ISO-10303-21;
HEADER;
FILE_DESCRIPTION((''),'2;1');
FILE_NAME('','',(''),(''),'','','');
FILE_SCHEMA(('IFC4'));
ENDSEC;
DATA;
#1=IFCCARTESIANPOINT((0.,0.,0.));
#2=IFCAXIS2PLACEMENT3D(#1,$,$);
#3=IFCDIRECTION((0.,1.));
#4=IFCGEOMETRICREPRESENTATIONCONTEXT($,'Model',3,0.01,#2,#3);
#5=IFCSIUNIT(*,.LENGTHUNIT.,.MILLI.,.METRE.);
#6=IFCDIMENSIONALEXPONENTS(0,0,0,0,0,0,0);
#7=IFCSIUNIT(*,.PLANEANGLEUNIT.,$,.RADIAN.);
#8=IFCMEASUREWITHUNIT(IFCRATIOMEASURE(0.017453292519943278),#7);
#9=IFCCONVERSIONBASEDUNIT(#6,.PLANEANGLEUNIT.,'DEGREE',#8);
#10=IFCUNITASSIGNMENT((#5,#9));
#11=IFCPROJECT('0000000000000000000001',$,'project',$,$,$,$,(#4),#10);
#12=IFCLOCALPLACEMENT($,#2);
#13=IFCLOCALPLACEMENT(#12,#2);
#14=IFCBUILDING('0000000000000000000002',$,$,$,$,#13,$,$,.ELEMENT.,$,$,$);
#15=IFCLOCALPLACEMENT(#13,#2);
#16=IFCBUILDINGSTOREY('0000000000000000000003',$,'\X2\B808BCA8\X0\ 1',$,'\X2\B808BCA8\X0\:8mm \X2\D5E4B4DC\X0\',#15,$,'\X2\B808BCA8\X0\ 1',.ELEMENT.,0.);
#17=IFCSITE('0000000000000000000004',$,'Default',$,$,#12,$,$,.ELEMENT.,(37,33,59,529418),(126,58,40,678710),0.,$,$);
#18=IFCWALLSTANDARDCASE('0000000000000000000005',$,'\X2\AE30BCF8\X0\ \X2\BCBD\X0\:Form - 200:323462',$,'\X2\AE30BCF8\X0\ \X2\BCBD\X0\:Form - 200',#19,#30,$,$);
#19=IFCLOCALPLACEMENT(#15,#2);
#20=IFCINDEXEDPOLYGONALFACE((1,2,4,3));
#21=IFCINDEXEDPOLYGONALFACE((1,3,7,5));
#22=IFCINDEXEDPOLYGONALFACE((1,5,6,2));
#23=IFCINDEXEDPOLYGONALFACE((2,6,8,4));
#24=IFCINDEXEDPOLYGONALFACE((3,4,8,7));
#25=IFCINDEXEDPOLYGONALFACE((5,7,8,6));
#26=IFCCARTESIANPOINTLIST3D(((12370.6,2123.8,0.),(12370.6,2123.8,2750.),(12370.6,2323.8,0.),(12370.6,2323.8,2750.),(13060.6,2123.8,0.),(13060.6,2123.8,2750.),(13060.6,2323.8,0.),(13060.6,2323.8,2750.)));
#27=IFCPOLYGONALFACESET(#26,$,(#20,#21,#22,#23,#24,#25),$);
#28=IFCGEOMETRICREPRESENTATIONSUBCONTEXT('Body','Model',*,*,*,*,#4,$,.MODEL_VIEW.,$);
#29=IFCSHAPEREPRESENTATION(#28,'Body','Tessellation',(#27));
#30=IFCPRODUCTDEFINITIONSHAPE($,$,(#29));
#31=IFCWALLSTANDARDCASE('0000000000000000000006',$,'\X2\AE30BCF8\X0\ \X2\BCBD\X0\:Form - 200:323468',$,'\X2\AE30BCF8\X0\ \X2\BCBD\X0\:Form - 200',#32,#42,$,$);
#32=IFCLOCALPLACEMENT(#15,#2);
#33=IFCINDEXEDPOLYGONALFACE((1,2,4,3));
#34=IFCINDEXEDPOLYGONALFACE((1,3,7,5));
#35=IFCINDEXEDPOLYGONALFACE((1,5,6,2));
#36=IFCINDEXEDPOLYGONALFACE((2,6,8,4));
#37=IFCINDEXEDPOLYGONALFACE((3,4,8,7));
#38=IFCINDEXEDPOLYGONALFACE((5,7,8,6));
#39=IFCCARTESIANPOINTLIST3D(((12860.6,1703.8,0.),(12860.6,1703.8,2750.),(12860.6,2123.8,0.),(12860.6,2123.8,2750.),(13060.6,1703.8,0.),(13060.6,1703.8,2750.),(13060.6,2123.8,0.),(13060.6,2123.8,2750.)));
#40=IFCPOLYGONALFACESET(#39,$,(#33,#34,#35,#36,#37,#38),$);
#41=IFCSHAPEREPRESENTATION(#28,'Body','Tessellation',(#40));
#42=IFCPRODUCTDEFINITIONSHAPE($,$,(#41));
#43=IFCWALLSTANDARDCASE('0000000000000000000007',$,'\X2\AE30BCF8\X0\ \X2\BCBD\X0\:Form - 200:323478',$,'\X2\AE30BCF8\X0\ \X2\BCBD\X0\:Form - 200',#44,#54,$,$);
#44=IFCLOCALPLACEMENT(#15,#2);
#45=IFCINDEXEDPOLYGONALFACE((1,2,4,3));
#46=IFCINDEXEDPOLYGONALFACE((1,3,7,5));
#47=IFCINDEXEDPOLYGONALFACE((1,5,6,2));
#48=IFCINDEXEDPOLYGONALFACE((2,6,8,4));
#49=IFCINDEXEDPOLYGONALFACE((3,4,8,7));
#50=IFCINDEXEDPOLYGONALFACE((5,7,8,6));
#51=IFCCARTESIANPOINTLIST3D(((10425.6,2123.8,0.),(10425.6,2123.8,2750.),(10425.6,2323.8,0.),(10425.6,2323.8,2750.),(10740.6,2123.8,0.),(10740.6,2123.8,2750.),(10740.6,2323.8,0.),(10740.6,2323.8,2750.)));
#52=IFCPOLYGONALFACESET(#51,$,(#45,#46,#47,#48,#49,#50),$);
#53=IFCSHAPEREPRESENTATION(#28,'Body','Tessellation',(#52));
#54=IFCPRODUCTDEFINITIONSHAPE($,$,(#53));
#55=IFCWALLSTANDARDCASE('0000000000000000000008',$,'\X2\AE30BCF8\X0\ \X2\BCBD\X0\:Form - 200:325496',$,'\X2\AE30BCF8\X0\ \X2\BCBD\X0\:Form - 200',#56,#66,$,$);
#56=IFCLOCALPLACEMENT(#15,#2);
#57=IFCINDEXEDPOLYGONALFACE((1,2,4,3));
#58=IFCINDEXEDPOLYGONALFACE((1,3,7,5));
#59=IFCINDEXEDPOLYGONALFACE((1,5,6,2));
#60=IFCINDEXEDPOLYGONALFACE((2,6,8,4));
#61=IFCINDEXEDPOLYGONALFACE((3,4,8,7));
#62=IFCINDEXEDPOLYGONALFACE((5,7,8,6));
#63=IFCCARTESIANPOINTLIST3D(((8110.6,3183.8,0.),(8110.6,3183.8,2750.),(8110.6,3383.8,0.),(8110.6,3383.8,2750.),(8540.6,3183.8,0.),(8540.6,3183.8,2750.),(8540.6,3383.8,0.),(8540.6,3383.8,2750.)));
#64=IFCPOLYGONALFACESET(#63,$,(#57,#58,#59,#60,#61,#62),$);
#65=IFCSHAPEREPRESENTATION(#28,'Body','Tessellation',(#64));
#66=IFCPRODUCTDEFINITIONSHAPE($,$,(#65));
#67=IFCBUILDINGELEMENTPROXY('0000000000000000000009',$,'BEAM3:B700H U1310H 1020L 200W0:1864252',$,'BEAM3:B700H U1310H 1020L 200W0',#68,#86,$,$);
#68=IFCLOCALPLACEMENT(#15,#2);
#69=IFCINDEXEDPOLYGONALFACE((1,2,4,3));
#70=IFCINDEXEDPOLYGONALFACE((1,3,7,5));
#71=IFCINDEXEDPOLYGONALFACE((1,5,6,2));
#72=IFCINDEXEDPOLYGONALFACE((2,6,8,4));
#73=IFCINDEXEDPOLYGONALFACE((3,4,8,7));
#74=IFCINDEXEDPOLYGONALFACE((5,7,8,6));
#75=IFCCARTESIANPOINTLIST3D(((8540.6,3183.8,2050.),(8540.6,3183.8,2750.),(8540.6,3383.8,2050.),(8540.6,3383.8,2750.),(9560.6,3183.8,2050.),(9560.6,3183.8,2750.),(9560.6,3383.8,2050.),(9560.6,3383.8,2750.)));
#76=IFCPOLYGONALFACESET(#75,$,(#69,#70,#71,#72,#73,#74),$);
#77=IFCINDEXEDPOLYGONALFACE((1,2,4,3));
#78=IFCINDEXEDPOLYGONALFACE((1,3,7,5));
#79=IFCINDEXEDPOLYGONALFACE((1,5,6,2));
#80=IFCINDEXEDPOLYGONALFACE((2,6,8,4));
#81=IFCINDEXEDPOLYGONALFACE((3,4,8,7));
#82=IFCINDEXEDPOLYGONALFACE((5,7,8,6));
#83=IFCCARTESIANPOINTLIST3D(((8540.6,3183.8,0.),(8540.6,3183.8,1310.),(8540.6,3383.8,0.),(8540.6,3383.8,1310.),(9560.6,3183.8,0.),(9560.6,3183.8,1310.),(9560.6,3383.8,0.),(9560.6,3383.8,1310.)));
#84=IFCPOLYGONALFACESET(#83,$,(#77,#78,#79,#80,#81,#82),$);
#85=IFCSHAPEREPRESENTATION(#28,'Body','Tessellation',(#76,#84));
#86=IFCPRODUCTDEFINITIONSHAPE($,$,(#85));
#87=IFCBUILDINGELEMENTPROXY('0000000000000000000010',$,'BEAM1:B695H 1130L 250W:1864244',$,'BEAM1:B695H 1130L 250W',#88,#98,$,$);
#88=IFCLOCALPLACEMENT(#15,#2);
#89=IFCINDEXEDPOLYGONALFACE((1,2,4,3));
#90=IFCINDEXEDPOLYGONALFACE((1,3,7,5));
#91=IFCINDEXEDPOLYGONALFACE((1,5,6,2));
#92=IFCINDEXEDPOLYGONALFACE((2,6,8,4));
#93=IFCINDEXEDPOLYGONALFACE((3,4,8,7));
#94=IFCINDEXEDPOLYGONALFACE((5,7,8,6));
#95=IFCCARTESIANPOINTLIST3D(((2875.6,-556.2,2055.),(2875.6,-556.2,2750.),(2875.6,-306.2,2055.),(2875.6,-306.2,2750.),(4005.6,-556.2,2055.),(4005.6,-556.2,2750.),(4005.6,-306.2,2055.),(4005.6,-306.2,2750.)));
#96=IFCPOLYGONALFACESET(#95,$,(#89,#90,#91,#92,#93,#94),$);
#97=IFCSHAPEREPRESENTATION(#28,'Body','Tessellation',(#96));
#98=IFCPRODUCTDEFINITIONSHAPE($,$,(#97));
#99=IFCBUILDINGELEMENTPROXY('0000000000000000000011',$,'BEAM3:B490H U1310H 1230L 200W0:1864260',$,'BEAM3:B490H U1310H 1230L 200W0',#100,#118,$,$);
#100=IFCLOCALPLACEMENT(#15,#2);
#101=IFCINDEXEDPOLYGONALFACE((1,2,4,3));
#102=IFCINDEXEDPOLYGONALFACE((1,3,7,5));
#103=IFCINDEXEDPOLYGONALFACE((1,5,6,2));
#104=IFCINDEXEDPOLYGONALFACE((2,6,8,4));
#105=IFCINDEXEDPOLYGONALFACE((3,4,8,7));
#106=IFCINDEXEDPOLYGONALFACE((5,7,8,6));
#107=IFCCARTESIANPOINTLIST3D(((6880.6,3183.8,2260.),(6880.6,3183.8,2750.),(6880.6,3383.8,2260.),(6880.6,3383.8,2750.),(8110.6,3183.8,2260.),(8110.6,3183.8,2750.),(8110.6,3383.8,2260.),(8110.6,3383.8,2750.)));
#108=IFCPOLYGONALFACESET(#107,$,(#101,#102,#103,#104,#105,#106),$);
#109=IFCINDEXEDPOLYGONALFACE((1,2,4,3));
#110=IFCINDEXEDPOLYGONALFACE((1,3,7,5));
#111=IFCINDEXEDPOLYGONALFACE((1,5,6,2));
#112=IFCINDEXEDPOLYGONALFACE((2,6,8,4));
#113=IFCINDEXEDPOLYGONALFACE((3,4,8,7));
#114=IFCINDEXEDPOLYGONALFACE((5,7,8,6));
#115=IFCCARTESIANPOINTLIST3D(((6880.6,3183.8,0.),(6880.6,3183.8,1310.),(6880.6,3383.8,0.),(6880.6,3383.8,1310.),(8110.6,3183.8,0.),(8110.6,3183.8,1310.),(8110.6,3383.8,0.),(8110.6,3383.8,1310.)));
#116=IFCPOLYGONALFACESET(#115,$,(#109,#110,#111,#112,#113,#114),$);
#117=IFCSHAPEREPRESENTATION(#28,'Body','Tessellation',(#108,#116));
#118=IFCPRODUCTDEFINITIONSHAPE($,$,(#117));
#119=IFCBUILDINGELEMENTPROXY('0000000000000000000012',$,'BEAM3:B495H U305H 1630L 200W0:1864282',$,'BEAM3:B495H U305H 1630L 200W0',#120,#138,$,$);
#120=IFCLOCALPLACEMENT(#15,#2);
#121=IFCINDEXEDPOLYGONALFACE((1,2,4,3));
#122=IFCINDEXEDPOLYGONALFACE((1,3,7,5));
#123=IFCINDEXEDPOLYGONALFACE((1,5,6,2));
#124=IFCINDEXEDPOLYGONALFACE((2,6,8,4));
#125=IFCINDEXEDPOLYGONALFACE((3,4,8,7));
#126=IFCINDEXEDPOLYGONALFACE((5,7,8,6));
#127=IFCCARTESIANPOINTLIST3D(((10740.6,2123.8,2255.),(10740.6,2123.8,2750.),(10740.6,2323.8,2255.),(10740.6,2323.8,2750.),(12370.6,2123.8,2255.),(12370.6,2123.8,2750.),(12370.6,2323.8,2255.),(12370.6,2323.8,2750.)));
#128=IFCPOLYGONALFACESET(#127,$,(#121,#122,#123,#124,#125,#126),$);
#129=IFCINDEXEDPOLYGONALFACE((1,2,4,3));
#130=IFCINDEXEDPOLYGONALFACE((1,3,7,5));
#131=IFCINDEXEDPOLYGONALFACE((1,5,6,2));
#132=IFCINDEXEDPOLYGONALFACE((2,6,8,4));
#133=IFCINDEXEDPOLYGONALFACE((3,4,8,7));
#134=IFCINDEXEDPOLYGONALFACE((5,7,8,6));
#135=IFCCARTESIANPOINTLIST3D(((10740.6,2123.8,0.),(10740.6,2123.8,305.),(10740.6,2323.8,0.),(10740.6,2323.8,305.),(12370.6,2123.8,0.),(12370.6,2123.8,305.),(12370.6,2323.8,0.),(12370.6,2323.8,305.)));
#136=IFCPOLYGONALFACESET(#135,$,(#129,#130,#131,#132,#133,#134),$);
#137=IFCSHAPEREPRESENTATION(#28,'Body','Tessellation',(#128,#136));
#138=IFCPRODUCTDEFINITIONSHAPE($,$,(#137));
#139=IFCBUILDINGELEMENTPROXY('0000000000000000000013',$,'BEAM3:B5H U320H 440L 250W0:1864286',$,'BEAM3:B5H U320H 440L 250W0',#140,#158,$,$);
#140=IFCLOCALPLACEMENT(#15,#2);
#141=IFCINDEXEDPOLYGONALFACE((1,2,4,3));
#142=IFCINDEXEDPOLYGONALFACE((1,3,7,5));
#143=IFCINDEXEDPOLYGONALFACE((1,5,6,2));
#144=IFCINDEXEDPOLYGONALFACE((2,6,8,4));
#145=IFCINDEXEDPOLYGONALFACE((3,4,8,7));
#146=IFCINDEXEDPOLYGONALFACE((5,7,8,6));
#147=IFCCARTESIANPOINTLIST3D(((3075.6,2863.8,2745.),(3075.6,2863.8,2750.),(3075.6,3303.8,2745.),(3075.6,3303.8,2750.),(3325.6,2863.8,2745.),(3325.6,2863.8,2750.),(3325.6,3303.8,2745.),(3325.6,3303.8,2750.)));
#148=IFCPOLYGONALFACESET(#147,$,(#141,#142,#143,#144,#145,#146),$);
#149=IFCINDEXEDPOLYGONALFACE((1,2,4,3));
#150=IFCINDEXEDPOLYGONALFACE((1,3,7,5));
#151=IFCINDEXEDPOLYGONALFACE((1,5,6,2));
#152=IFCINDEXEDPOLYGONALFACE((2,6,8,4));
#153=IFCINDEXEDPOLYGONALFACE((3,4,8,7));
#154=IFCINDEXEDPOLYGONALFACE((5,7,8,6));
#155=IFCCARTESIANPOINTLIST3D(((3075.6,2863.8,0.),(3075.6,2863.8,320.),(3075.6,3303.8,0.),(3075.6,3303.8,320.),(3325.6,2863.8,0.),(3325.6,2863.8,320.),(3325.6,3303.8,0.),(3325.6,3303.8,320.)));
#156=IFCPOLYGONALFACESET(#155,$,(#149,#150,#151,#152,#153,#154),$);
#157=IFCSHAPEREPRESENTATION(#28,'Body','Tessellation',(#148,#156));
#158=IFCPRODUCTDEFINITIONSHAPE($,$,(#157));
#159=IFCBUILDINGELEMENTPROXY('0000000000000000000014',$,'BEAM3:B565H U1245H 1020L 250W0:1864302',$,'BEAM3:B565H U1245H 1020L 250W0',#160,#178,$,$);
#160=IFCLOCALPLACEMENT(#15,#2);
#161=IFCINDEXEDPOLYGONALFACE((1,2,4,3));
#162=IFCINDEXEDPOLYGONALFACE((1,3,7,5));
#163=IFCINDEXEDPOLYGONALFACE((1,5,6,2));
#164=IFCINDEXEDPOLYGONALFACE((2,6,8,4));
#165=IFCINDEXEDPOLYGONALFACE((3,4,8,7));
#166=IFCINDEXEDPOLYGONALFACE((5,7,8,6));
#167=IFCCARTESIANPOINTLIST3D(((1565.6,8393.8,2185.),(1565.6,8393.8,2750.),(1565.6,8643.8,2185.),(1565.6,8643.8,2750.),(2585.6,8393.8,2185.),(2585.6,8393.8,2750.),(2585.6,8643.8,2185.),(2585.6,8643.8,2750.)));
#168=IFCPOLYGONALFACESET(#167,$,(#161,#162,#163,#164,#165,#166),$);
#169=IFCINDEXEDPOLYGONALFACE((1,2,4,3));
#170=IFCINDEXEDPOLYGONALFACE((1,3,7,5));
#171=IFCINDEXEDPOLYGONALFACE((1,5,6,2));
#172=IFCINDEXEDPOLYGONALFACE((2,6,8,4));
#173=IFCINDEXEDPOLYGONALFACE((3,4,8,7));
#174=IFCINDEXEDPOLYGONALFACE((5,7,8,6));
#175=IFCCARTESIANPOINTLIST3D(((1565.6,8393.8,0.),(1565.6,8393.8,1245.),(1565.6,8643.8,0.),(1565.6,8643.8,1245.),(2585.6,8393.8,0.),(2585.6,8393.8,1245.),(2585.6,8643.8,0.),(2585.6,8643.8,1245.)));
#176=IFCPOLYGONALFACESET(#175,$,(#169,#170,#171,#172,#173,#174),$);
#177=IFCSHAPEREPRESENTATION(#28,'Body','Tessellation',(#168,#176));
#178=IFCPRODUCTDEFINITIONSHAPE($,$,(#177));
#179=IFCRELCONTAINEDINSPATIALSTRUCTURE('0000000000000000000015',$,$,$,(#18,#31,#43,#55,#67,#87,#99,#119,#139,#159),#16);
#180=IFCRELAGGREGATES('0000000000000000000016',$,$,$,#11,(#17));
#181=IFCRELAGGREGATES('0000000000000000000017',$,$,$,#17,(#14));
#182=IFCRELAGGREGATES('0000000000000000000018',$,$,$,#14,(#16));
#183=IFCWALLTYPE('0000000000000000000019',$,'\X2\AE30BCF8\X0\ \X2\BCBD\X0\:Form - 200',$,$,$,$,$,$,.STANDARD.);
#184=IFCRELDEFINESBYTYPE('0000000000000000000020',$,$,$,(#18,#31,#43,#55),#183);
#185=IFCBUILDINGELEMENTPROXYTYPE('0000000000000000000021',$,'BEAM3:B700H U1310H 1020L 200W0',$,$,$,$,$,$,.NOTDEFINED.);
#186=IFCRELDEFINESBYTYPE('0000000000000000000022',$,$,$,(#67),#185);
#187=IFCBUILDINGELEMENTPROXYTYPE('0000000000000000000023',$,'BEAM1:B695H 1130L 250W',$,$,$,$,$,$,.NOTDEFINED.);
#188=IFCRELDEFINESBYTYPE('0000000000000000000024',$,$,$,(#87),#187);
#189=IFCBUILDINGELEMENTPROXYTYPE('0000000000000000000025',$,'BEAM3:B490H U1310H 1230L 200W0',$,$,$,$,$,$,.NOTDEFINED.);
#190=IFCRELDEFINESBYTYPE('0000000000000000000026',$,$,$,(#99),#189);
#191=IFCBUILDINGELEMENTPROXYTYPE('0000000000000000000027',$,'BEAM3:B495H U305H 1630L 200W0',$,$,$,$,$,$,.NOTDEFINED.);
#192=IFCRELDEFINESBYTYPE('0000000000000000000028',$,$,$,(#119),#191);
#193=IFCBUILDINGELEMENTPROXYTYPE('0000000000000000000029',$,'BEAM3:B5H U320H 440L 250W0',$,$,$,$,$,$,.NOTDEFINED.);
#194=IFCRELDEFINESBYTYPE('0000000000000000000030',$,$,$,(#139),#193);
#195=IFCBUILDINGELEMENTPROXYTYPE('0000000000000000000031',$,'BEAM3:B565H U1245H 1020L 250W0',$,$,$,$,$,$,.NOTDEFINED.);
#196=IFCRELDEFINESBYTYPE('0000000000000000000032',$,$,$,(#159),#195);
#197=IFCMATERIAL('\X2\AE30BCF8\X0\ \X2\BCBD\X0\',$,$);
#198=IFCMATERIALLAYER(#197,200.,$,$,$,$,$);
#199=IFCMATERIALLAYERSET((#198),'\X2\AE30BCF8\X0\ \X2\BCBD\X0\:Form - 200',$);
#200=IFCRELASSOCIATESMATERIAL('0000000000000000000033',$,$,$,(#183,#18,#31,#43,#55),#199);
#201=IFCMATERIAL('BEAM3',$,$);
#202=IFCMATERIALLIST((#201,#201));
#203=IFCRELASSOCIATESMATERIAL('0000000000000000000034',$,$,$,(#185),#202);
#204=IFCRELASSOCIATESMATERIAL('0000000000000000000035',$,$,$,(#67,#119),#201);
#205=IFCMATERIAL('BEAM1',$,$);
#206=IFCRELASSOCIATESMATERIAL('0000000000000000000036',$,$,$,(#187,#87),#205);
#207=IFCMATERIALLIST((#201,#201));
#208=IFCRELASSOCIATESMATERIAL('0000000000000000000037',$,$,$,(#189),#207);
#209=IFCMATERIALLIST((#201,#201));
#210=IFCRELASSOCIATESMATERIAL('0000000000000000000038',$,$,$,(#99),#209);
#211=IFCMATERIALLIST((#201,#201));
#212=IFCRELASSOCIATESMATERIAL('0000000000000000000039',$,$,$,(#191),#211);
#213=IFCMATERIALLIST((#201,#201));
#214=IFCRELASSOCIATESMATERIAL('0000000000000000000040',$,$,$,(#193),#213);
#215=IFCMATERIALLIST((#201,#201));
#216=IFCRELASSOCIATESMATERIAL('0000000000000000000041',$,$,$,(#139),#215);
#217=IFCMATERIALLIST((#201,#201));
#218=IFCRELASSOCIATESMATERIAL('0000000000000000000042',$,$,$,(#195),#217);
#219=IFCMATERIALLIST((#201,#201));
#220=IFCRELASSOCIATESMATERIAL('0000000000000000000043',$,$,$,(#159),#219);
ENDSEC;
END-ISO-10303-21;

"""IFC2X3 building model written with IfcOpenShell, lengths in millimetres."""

from ifc_helpers import new_model, entity, si_unit, converted_unit, direction, frame, frame_2d, origin, origin_2d_with_axis, place, context, subcontext, project, spatial, rectangle, extrude, source, transform, mapped, material, material_list, layer, layer_set, layer_usage, type_object, type_shapes, element, save


model = new_model("IFC2X3")

# Units and contexts
model_context = context("Model", 3, precision=0.01, world=origin(), true_north=direction((0.0, 1.0)))
body_context = subcontext(model_context, "Body", "Model", "MODEL_VIEW")
ifc_project = project(units=[si_unit("LENGTHUNIT", "METRE", prefix="MILLI"), converted_unit("PLANEANGLEUNIT", "DEGREE", entity("IfcRatioMeasure", 0.017453292519943278), si_unit("PLANEANGLEUNIT", "RADIAN"), dimensions=[0, 0, 0, 0, 0, 0, 0])], contexts=[model_context])

# Site, building, storey
site_placement = place(None, origin())
site = spatial("IfcSite", under=ifc_project, at=site_placement, Name="Default", CompositionType="ELEMENT", RefLatitude=(37, 33, 59, 529418), RefLongitude=(126, 58, 40, 678710), RefElevation=0.0)
building_placement = place(site_placement, origin())
building = spatial("IfcBuilding", under=site, at=building_placement, CompositionType="ELEMENT")
storey_placement = place(building_placement, origin())
storey = spatial("IfcBuildingStorey", under=building, at=storey_placement, Name="레벨 1", ObjectType="레벨:8mm 헤드", LongName="레벨 1", CompositionType="ELEMENT", Elevation=0.0)

# Walls
ifc_material_1 = material(Name="기본 벽")
ifc_layer_1 = layer(ifc_material_1, 200.0)
ifc_layer_set_1 = layer_set([ifc_layer_1], Name="기본 벽:Form - 200")
wall_type_1 = type_object("IfcWallType", Name="기본 벽:Form - 200", PredefinedType="STANDARD", material=ifc_layer_set_1)
ifc_layer_usage_1 = layer_usage(ifc_layer_set_1, "AXIS2", "POSITIVE", -100.0)
wall_1_placement = place(storey_placement, frame((13060.6, 2223.8, 0.0), z_axis=(0.0, 0.0, 1.0), x_axis=(-1.0, 0.0, 0.0)))
element("IfcWallStandardCase", 1, at=wall_1_placement, inside=storey, type_object=wall_type_1, material=ifc_layer_usage_1, Name="기본 벽:Form - 200:323462", ObjectType="기본 벽:Form - 200", context=body_context, shape_type="SweptSolid", body=[
    extrude(rectangle(XDim=690.0, YDim=200.0, at=frame_2d((345.0, 0.0), x_axis=(-1.0, 0.0))), origin(), (0.0, 0.0, 1.0), 2750.0),
])
ifc_layer_usage_2 = layer_usage(ifc_layer_set_1, "AXIS2", "POSITIVE", -100.0)
wall_2_placement = place(storey_placement, frame((12960.6, 1703.8, 0.0), z_axis=(0.0, 0.0, 1.0), x_axis=(0.0, 1.0, 0.0)))
element("IfcWallStandardCase", 2, at=wall_2_placement, inside=storey, type_object=wall_type_1, material=ifc_layer_usage_2, Name="기본 벽:Form - 200:323468", ObjectType="기본 벽:Form - 200", context=body_context, shape_type="SweptSolid", body=[
    extrude(rectangle(XDim=420.0, YDim=200.0, at=frame_2d((210.0, 0.0), x_axis=(-1.0, 0.0))), origin(), (0.0, 0.0, 1.0), 2750.0),
])
ifc_layer_usage_3 = layer_usage(ifc_layer_set_1, "AXIS2", "POSITIVE", -100.0)
wall_3_placement = place(storey_placement, frame((10740.6, 2223.8, 0.0), z_axis=(0.0, 0.0, 1.0), x_axis=(-1.0, 0.0, 0.0)))
element("IfcWallStandardCase", 3, at=wall_3_placement, inside=storey, type_object=wall_type_1, material=ifc_layer_usage_3, Name="기본 벽:Form - 200:323478", ObjectType="기본 벽:Form - 200", context=body_context, shape_type="SweptSolid", body=[
    extrude(rectangle(XDim=315.0, YDim=200.0, at=frame_2d((157.5, 0.0), x_axis=(-1.0, 0.0))), origin(), (0.0, 0.0, 1.0), 2750.0),
])
ifc_layer_usage_4 = layer_usage(ifc_layer_set_1, "AXIS2", "POSITIVE", -100.0)
wall_4_placement = place(storey_placement, frame((8110.6, 3283.8, 0.0)))
element("IfcWallStandardCase", 4, at=wall_4_placement, inside=storey, type_object=wall_type_1, material=ifc_layer_usage_4, Name="기본 벽:Form - 200:325496", ObjectType="기본 벽:Form - 200", context=body_context, shape_type="SweptSolid", body=[
    extrude(rectangle(XDim=430.0, YDim=200.0, at=frame_2d((215.0, 0.0), x_axis=(-1.0, 0.0))), origin(), (0.0, 0.0, 1.0), 2750.0),
])

# Building element proxies
ifc_material_2 = material(Name="BEAM3")
ifc_material_list_1 = material_list([ifc_material_2, ifc_material_2])
building_element_proxy_type_1 = type_object("IfcBuildingElementProxyType", Name="BEAM3:B700H U1310H 1020L 200W0", PredefinedType="NOTDEFINED", material=ifc_material_list_1)
shared_shape_1 = source(origin(), body_context, "Body", "SweptSolid", [
    extrude(rectangle(XDim=1020.0, YDim=200.0, at=origin_2d_with_axis()), frame((510.0, -100.0, 2050.0)), (0.0, 0.0, 1.0), 700.0),
    extrude(rectangle(XDim=1020.0, YDim=200.0, at=origin_2d_with_axis()), frame((510.0, -100.0, 0.0)), (0.0, 0.0, 1.0), 1310.0),
])
type_shapes(building_element_proxy_type_1, [shared_shape_1])
proxy_1_placement = place(storey_placement, frame((9560.6, 3183.8, 0.0), z_axis=(0.0, 0.0, 1.0), x_axis=(-1.0, 0.0, 0.0)))
element("IfcBuildingElementProxy", 5, at=proxy_1_placement, inside=storey, type_object=building_element_proxy_type_1, material=ifc_material_2, Name="BEAM3:B700H U1310H 1020L 200W0:1864252", ObjectType="BEAM3:B700H U1310H 1020L 200W0", context=body_context, shape_type="MappedRepresentation", body=[
    mapped(shared_shape_1, transform((0.0, 0.0, 0.0), scale=1.0)),
])
ifc_material_3 = material(Name="BEAM1")
building_element_proxy_type_2 = type_object("IfcBuildingElementProxyType", Name="BEAM1:B695H 1130L 250W", PredefinedType="NOTDEFINED", material=ifc_material_3)
shared_shape_2 = source(origin(), body_context, "Body", "SweptSolid", [
    extrude(rectangle(XDim=1130.0, YDim=250.0, at=origin_2d_with_axis()), frame((565.0, -125.0, -695.0)), (0.0, 0.0, 1.0), 695.0),
])
type_shapes(building_element_proxy_type_2, [shared_shape_2])
proxy_2_placement = place(storey_placement, frame((2875.6, -306.2, 2750.0)))
element("IfcBuildingElementProxy", 6, at=proxy_2_placement, inside=storey, type_object=building_element_proxy_type_2, material=ifc_material_3, Name="BEAM1:B695H 1130L 250W:1864244", ObjectType="BEAM1:B695H 1130L 250W", context=body_context, shape_type="MappedRepresentation", body=[
    mapped(shared_shape_2, transform((0.0, 0.0, 0.0), scale=1.0)),
])
ifc_material_list_2 = material_list([ifc_material_2, ifc_material_2])
ifc_material_list_3 = material_list([ifc_material_2, ifc_material_2])
building_element_proxy_type_3 = type_object("IfcBuildingElementProxyType", Name="BEAM3:B490H U1310H 1230L 200W0", PredefinedType="NOTDEFINED", material=ifc_material_list_3)
shared_shape_3 = source(origin(), body_context, "Body", "SweptSolid", [
    extrude(rectangle(XDim=1230.0, YDim=200.0, at=origin_2d_with_axis()), frame((615.0, -100.0, 2260.0)), (0.0, 0.0, 1.0), 490.0),
    extrude(rectangle(XDim=1230.0, YDim=200.0, at=origin_2d_with_axis()), frame((615.0, -100.0, 0.0)), (0.0, 0.0, 1.0), 1310.0),
])
type_shapes(building_element_proxy_type_3, [shared_shape_3])
proxy_3_placement = place(storey_placement, frame((8110.6, 3183.8, 0.0), z_axis=(0.0, 0.0, 1.0), x_axis=(-1.0, 0.0, 0.0)))
element("IfcBuildingElementProxy", 7, at=proxy_3_placement, inside=storey, type_object=building_element_proxy_type_3, material=ifc_material_list_2, Name="BEAM3:B490H U1310H 1230L 200W0:1864260", ObjectType="BEAM3:B490H U1310H 1230L 200W0", context=body_context, shape_type="MappedRepresentation", body=[
    mapped(shared_shape_3, transform((0.0, 0.0, 0.0), scale=1.0)),
])
ifc_material_list_4 = material_list([ifc_material_2, ifc_material_2])
building_element_proxy_type_4 = type_object("IfcBuildingElementProxyType", Name="BEAM3:B495H U305H 1630L 200W0", PredefinedType="NOTDEFINED", material=ifc_material_list_4)
shared_shape_4 = source(origin(), body_context, "Body", "SweptSolid", [
    extrude(rectangle(XDim=1630.0, YDim=200.0, at=origin_2d_with_axis()), frame((815.0, -100.0, 2255.0)), (0.0, 0.0, 1.0), 495.0),
    extrude(rectangle(XDim=1630.0, YDim=200.0, at=origin_2d_with_axis()), frame((815.0, -100.0, 0.0)), (0.0, 0.0, 1.0), 305.0),
])
type_shapes(building_element_proxy_type_4, [shared_shape_4])
proxy_4_placement = place(storey_placement, frame((10740.6, 2323.8, 0.0)))
element("IfcBuildingElementProxy", 8, at=proxy_4_placement, inside=storey, type_object=building_element_proxy_type_4, material=ifc_material_2, Name="BEAM3:B495H U305H 1630L 200W0:1864282", ObjectType="BEAM3:B495H U305H 1630L 200W0", context=body_context, shape_type="MappedRepresentation", body=[
    mapped(shared_shape_4, transform((0.0, 0.0, 0.0), scale=1.0)),
])
ifc_material_list_5 = material_list([ifc_material_2, ifc_material_2])
ifc_material_list_6 = material_list([ifc_material_2, ifc_material_2])
building_element_proxy_type_5 = type_object("IfcBuildingElementProxyType", Name="BEAM3:B5H U320H 440L 250W0", PredefinedType="NOTDEFINED", material=ifc_material_list_6)
shared_shape_5 = source(origin(), body_context, "Body", "SweptSolid", [
    extrude(rectangle(XDim=440.0, YDim=250.0, at=origin_2d_with_axis()), frame((220.0, -125.0, 2745.0)), (0.0, 0.0, 1.0), 5.0),
    extrude(rectangle(XDim=440.0, YDim=250.0, at=origin_2d_with_axis()), frame((220.0, -125.0, 0.0)), (0.0, 0.0, 1.0), 320.0),
])
type_shapes(building_element_proxy_type_5, [shared_shape_5])
proxy_5_placement = place(storey_placement, frame((3075.6, 2863.8, 0.0), z_axis=(0.0, 0.0, 1.0), x_axis=(0.0, 1.0, 0.0)))
element("IfcBuildingElementProxy", 9, at=proxy_5_placement, inside=storey, type_object=building_element_proxy_type_5, material=ifc_material_list_5, Name="BEAM3:B5H U320H 440L 250W0:1864286", ObjectType="BEAM3:B5H U320H 440L 250W0", context=body_context, shape_type="MappedRepresentation", body=[
    mapped(shared_shape_5, transform((0.0, 0.0, 0.0), scale=1.0)),
])
ifc_material_list_7 = material_list([ifc_material_2, ifc_material_2])
ifc_material_list_8 = material_list([ifc_material_2, ifc_material_2])
building_element_proxy_type_6 = type_object("IfcBuildingElementProxyType", Name="BEAM3:B565H U1245H 1020L 250W0", PredefinedType="NOTDEFINED", material=ifc_material_list_8)
shared_shape_6 = source(origin(), body_context, "Body", "SweptSolid", [
    extrude(rectangle(XDim=1020.0, YDim=250.0, at=origin_2d_with_axis()), frame((510.0, -125.0, 2185.0)), (0.0, 0.0, 1.0), 565.0),
    extrude(rectangle(XDim=1020.0, YDim=250.0, at=origin_2d_with_axis()), frame((510.0, -125.0, 0.0)), (0.0, 0.0, 1.0), 1245.0),
])
type_shapes(building_element_proxy_type_6, [shared_shape_6])
proxy_6_placement = place(storey_placement, frame((2585.6, 8393.8, 0.0), z_axis=(0.0, 0.0, 1.0), x_axis=(-1.0, 0.0, 0.0)))
element("IfcBuildingElementProxy", 10, at=proxy_6_placement, inside=storey, type_object=building_element_proxy_type_6, material=ifc_material_list_7, Name="BEAM3:B565H U1245H 1020L 250W0:1864302", ObjectType="BEAM3:B565H U1245H 1020L 250W0", context=body_context, shape_type="MappedRepresentation", body=[
    mapped(shared_shape_6, transform((0.0, 0.0, 0.0), scale=1.0)),
])

save(model, "model.ifc")
